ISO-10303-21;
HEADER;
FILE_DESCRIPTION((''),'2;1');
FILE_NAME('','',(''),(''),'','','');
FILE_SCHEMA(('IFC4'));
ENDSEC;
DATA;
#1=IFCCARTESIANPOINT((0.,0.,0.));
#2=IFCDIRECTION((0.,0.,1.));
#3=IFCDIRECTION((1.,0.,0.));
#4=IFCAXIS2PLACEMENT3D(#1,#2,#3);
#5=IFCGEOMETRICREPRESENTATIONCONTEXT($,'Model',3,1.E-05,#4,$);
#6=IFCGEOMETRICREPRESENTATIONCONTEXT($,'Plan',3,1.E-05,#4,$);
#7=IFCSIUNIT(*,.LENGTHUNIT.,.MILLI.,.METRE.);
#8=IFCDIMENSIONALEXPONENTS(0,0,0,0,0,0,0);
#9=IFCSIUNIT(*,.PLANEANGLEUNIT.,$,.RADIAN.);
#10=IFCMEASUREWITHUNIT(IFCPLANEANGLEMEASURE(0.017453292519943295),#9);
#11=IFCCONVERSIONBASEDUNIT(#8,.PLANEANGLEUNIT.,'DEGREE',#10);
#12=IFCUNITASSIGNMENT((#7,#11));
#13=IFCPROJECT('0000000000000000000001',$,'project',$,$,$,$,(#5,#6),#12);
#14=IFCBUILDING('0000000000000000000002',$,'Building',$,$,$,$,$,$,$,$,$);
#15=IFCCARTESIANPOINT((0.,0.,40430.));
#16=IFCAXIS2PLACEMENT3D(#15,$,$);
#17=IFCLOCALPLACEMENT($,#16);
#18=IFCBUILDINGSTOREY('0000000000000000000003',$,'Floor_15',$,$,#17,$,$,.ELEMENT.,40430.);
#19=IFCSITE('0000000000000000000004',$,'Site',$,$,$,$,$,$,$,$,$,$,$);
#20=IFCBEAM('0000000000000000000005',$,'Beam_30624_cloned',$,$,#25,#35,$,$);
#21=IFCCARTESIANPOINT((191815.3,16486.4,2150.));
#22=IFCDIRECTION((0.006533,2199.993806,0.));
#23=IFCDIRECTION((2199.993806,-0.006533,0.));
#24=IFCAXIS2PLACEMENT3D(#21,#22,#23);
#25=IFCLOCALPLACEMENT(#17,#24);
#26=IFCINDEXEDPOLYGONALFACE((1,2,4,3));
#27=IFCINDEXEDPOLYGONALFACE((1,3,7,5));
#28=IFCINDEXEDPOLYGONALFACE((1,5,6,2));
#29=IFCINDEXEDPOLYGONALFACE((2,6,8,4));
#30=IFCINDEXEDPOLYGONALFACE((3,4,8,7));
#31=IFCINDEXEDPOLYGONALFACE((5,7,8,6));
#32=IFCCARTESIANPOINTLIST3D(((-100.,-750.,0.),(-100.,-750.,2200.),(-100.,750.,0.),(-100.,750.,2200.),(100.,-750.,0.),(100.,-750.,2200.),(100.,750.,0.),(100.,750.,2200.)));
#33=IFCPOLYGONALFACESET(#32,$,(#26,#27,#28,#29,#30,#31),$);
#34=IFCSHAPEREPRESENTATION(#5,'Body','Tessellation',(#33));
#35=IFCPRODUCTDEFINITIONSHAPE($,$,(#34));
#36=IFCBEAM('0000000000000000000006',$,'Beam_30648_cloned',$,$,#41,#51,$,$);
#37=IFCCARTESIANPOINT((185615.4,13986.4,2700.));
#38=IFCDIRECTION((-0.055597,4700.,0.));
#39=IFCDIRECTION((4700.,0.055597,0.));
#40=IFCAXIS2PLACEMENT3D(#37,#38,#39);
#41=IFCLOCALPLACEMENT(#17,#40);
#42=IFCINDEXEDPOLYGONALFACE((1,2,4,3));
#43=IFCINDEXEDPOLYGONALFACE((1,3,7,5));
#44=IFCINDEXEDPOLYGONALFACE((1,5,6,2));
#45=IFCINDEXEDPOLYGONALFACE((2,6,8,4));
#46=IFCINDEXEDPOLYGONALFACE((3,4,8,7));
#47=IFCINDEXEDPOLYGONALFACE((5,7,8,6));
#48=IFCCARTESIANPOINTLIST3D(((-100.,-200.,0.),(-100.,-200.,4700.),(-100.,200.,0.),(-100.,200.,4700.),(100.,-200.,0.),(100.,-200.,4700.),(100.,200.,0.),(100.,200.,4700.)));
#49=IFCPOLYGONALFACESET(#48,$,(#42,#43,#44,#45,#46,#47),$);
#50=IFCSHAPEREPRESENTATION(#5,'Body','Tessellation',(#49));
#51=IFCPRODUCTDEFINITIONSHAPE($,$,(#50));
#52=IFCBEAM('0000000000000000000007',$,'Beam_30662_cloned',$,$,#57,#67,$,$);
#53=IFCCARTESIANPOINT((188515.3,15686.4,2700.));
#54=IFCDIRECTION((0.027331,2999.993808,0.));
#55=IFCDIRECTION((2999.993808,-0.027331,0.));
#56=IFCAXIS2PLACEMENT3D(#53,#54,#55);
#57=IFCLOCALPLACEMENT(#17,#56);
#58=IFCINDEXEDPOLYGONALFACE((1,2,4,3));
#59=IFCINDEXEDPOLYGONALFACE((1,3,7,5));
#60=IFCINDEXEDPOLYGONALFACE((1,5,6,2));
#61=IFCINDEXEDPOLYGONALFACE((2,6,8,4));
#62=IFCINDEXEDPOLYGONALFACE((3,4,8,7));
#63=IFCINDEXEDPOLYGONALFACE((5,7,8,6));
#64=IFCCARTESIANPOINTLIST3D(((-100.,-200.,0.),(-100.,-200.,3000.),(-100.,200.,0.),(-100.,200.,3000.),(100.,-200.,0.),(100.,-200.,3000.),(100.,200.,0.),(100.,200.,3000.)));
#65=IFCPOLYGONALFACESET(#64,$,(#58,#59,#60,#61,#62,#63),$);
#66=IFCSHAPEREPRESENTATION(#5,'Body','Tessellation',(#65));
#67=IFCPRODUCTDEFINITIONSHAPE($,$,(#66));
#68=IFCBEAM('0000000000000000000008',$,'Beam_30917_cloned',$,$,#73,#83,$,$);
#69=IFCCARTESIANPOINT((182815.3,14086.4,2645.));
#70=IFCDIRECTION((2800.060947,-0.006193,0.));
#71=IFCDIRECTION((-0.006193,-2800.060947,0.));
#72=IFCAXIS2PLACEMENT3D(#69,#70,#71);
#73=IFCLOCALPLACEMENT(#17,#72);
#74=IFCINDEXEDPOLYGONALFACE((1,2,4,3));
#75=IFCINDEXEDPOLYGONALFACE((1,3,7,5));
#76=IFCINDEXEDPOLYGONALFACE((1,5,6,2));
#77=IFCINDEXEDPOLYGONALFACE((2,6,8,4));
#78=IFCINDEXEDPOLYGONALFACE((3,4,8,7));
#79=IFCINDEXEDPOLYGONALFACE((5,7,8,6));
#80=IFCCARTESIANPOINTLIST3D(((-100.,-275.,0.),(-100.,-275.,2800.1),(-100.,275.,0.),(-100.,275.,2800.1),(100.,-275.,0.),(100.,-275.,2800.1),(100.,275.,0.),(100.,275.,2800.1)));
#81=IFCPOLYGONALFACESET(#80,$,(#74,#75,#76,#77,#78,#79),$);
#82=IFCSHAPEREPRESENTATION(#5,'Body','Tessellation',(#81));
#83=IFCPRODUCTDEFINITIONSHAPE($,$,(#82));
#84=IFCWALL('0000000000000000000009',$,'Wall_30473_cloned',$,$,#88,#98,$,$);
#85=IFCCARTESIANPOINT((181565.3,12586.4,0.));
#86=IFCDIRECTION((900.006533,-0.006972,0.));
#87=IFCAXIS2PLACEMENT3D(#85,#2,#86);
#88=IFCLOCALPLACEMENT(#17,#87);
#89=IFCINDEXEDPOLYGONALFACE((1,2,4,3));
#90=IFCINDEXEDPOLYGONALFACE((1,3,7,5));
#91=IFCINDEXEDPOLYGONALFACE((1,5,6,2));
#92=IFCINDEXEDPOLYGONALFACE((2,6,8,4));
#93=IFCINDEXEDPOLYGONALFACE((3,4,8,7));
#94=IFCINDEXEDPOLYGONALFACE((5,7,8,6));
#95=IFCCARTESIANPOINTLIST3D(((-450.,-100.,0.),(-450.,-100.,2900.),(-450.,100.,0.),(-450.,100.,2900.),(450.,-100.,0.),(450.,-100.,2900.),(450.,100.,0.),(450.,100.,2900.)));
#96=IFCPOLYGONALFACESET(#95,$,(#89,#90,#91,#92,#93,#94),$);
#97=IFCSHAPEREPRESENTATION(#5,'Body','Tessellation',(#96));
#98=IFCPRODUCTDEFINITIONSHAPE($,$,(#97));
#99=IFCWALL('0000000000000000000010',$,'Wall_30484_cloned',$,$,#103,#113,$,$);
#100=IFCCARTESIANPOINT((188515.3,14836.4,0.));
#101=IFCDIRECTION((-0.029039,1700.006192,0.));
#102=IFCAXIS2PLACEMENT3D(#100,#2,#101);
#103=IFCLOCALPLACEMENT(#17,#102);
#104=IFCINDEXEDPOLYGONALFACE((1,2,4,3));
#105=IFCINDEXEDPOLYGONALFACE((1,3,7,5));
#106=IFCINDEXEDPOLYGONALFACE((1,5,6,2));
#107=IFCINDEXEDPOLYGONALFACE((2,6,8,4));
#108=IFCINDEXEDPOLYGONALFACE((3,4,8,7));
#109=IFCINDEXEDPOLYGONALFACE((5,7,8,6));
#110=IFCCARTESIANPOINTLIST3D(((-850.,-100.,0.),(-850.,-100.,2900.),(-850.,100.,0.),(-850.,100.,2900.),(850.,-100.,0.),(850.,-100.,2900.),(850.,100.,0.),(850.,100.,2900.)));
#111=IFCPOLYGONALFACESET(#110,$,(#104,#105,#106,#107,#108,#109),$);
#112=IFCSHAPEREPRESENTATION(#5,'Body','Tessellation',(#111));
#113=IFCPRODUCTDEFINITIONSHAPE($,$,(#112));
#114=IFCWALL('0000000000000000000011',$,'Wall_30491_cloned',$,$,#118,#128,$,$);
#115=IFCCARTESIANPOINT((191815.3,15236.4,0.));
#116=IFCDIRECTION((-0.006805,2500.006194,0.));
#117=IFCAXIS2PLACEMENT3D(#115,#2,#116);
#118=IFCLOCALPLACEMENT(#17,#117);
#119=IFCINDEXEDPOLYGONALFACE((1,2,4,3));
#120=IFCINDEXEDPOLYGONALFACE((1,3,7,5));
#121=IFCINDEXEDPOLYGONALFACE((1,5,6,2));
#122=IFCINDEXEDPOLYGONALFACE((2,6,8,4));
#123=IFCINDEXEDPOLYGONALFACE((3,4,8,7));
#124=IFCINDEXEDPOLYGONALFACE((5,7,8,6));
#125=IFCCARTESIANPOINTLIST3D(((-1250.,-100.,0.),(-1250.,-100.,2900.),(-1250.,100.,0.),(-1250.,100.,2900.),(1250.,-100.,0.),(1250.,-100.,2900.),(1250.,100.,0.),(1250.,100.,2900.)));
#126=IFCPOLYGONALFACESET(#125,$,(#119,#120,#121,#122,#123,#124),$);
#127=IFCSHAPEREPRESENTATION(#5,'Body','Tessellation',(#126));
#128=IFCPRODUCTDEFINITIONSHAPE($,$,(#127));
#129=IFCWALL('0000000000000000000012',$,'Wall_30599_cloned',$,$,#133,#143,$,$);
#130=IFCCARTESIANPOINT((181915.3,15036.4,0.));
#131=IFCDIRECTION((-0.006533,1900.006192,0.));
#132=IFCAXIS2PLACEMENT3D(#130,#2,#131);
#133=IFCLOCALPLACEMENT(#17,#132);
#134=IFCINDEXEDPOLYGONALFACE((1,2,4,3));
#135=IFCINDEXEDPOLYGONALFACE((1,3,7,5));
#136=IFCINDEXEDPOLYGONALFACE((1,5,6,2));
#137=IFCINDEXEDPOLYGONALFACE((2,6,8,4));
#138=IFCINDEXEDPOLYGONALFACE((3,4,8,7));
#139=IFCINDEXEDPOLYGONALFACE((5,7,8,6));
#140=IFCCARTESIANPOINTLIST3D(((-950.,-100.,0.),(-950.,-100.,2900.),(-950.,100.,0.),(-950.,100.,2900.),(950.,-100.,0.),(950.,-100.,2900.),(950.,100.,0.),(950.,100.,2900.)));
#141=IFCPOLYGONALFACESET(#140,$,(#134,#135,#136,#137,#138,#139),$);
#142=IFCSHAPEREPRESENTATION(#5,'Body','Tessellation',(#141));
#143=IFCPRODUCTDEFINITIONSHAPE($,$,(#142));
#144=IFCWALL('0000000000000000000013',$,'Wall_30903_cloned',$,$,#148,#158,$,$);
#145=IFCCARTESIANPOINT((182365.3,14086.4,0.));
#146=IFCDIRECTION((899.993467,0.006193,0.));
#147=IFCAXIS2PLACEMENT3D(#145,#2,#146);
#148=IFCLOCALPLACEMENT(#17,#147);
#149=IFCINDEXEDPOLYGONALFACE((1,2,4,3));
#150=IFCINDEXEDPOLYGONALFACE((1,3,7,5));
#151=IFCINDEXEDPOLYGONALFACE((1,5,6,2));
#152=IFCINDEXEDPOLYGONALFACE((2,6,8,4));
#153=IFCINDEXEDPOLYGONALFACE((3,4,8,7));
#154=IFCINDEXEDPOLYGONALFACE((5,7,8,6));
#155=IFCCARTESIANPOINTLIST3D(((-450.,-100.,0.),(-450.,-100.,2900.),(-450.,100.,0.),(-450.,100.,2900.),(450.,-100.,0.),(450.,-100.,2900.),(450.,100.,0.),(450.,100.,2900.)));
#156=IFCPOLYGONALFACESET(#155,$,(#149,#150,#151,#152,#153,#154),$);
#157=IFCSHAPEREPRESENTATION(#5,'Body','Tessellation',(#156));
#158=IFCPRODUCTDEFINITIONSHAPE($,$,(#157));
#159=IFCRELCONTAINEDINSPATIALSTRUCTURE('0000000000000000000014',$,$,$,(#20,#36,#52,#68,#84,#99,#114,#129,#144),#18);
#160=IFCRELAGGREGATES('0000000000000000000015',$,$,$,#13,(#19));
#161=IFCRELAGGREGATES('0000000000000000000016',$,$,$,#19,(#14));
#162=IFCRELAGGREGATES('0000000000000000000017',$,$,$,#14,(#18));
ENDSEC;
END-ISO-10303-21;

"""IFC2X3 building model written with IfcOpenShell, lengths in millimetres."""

from ifc_helpers import new_model, entity, si_unit, converted_unit, frame, origin_with_axes, origin_2d, place, context, project, spatial, rectangle, extrude, source, transform, mapped, element, save


model = new_model("IFC2X3")

# Units and contexts
model_context = context("Model", 3, precision=1e-05, world=origin_with_axes())
plan_context = context("Plan", 3, precision=1e-05, world=origin_with_axes())
ifc_project = project(units=[si_unit("LENGTHUNIT", "METRE", prefix="MILLI"), converted_unit("PLANEANGLEUNIT", "DEGREE", entity("IfcPlaneAngleMeasure", 0.017453292519943295), si_unit("PLANEANGLEUNIT", "RADIAN"), dimensions=[0, 0, 0, 0, 0, 0, 0])], contexts=[model_context, plan_context])

# Site, building, storey
site = spatial("IfcSite", under=ifc_project, Name="Site")
building = spatial("IfcBuilding", under=site, Name="Building")
storey_placement = place(None, frame((0.0, 0.0, 40430.0)))
storey = spatial("IfcBuildingStorey", under=building, at=storey_placement, Name="Floor_15", CompositionType="ELEMENT", Elevation=40430.0)

# Beams
shared_shape_1 = source(origin_with_axes(), model_context, "Body", "SweptSolid", [
    extrude(rectangle(XDim=200.0, YDim=1500.0, at=origin_2d()), origin_with_axes(), (0.0, 0.0, 1.0), 2200.0),
])
beam_1_placement = place(storey_placement, frame((191815.3, 16486.4, 2150.0), z_axis=(0.006533, 2199.993806, 0.0), x_axis=(2199.993806, -0.006533, 0.0)))
element("IfcBeam", 1, at=beam_1_placement, inside=storey, Name="Beam_30624_cloned", context=model_context, shape_type="MappedRepresentation", body=[
    mapped(shared_shape_1, transform((0.0, 0.0, 0.0), x_axis=(1.0, 0.0, 0.0), y_axis=(0.0, 1.0, 0.0), z_axis=(0.0, 0.0, 1.0), scale=1.0)),
])
shared_shape_2 = source(origin_with_axes(), model_context, "Body", "SweptSolid", [
    extrude(rectangle(XDim=200.0, YDim=400.0, at=origin_2d()), origin_with_axes(), (0.0, 0.0, 1.0), 4700.0),
])
beam_2_placement = place(storey_placement, frame((185615.4, 13986.4, 2700.0), z_axis=(-0.055597, 4700.0, 0.0), x_axis=(4700.0, 0.055597, 0.0)))
element("IfcBeam", 2, at=beam_2_placement, inside=storey, Name="Beam_30648_cloned", context=model_context, shape_type="MappedRepresentation", body=[
    mapped(shared_shape_2, transform((0.0, 0.0, 0.0), x_axis=(1.0, 0.0, 0.0), y_axis=(0.0, 1.0, 0.0), z_axis=(0.0, 0.0, 1.0), scale=1.0)),
])
shared_shape_3 = source(origin_with_axes(), model_context, "Body", "SweptSolid", [
    extrude(rectangle(XDim=200.0, YDim=400.0, at=origin_2d()), origin_with_axes(), (0.0, 0.0, 1.0), 3000.0),
])
beam_3_placement = place(storey_placement, frame((188515.3, 15686.4, 2700.0), z_axis=(0.027331, 2999.993808, 0.0), x_axis=(2999.993808, -0.027331, 0.0)))
element("IfcBeam", 3, at=beam_3_placement, inside=storey, Name="Beam_30662_cloned", context=model_context, shape_type="MappedRepresentation", body=[
    mapped(shared_shape_3, transform((0.0, 0.0, 0.0), x_axis=(1.0, 0.0, 0.0), y_axis=(0.0, 1.0, 0.0), z_axis=(0.0, 0.0, 1.0), scale=1.0)),
])
shared_shape_4 = source(origin_with_axes(), model_context, "Body", "SweptSolid", [
    extrude(rectangle(XDim=200.0, YDim=550.0, at=origin_2d()), origin_with_axes(), (0.0, 0.0, 1.0), 2800.1),
])
beam_4_placement = place(storey_placement, frame((182815.3, 14086.4, 2645.0), z_axis=(2800.060947, -0.006193, 0.0), x_axis=(-0.006193, -2800.060947, 0.0)))
element("IfcBeam", 4, at=beam_4_placement, inside=storey, Name="Beam_30917_cloned", context=model_context, shape_type="MappedRepresentation", body=[
    mapped(shared_shape_4, transform((0.0, 0.0, 0.0), x_axis=(1.0, 0.0, 0.0), y_axis=(0.0, 1.0, 0.0), z_axis=(0.0, 0.0, 1.0), scale=1.0)),
])

# Walls
shared_shape_5 = source(origin_with_axes(), model_context, "Body", "SweptSolid", [
    extrude(rectangle(XDim=900.0, YDim=200.0, at=origin_2d()), origin_with_axes(), (0.0, 0.0, 1.0), 2900.0),
])
wall_1_placement = place(storey_placement, frame((181565.3, 12586.4, 0.0), z_axis=(0.0, 0.0, 1.0), x_axis=(900.006533, -0.006972, 0.0)))
element("IfcWall", 5, at=wall_1_placement, inside=storey, Name="Wall_30473_cloned", context=model_context, shape_type="MappedRepresentation", body=[
    mapped(shared_shape_5, transform((0.0, 0.0, 0.0), x_axis=(1.0, 0.0, 0.0), y_axis=(0.0, 1.0, 0.0), z_axis=(0.0, 0.0, 1.0), scale=1.0)),
])
shared_shape_6 = source(origin_with_axes(), model_context, "Body", "SweptSolid", [
    extrude(rectangle(XDim=1700.0, YDim=200.0, at=origin_2d()), origin_with_axes(), (0.0, 0.0, 1.0), 2900.0),
])
wall_2_placement = place(storey_placement, frame((188515.3, 14836.4, 0.0), z_axis=(0.0, 0.0, 1.0), x_axis=(-0.029039, 1700.006192, 0.0)))
element("IfcWall", 6, at=wall_2_placement, inside=storey, Name="Wall_30484_cloned", context=model_context, shape_type="MappedRepresentation", body=[
    mapped(shared_shape_6, transform((0.0, 0.0, 0.0), x_axis=(1.0, 0.0, 0.0), y_axis=(0.0, 1.0, 0.0), z_axis=(0.0, 0.0, 1.0), scale=1.0)),
])
shared_shape_7 = source(origin_with_axes(), model_context, "Body", "SweptSolid", [
    extrude(rectangle(XDim=2500.0, YDim=200.0, at=origin_2d()), origin_with_axes(), (0.0, 0.0, 1.0), 2900.0),
])
wall_3_placement = place(storey_placement, frame((191815.3, 15236.4, 0.0), z_axis=(0.0, 0.0, 1.0), x_axis=(-0.006805, 2500.006194, 0.0)))
element("IfcWall", 7, at=wall_3_placement, inside=storey, Name="Wall_30491_cloned", context=model_context, shape_type="MappedRepresentation", body=[
    mapped(shared_shape_7, transform((0.0, 0.0, 0.0), x_axis=(1.0, 0.0, 0.0), y_axis=(0.0, 1.0, 0.0), z_axis=(0.0, 0.0, 1.0), scale=1.0)),
])
shared_shape_8 = source(origin_with_axes(), model_context, "Body", "SweptSolid", [
    extrude(rectangle(XDim=1900.0, YDim=200.0, at=origin_2d()), origin_with_axes(), (0.0, 0.0, 1.0), 2900.0),
])
wall_4_placement = place(storey_placement, frame((181915.3, 15036.4, 0.0), z_axis=(0.0, 0.0, 1.0), x_axis=(-0.006533, 1900.006192, 0.0)))
element("IfcWall", 8, at=wall_4_placement, inside=storey, Name="Wall_30599_cloned", context=model_context, shape_type="MappedRepresentation", body=[
    mapped(shared_shape_8, transform((0.0, 0.0, 0.0), x_axis=(1.0, 0.0, 0.0), y_axis=(0.0, 1.0, 0.0), z_axis=(0.0, 0.0, 1.0), scale=1.0)),
])
shared_shape_9 = source(origin_with_axes(), model_context, "Body", "SweptSolid", [
    extrude(rectangle(XDim=900.0, YDim=200.0, at=origin_2d()), origin_with_axes(), (0.0, 0.0, 1.0), 2900.0),
])
wall_5_placement = place(storey_placement, frame((182365.3, 14086.4, 0.0), z_axis=(0.0, 0.0, 1.0), x_axis=(899.993467, 0.006193, 0.0)))
element("IfcWall", 9, at=wall_5_placement, inside=storey, Name="Wall_30903_cloned", context=model_context, shape_type="MappedRepresentation", body=[
    mapped(shared_shape_9, transform((0.0, 0.0, 0.0), x_axis=(1.0, 0.0, 0.0), y_axis=(0.0, 1.0, 0.0), z_axis=(0.0, 0.0, 1.0), scale=1.0)),
])

save(model, "model.ifc")
